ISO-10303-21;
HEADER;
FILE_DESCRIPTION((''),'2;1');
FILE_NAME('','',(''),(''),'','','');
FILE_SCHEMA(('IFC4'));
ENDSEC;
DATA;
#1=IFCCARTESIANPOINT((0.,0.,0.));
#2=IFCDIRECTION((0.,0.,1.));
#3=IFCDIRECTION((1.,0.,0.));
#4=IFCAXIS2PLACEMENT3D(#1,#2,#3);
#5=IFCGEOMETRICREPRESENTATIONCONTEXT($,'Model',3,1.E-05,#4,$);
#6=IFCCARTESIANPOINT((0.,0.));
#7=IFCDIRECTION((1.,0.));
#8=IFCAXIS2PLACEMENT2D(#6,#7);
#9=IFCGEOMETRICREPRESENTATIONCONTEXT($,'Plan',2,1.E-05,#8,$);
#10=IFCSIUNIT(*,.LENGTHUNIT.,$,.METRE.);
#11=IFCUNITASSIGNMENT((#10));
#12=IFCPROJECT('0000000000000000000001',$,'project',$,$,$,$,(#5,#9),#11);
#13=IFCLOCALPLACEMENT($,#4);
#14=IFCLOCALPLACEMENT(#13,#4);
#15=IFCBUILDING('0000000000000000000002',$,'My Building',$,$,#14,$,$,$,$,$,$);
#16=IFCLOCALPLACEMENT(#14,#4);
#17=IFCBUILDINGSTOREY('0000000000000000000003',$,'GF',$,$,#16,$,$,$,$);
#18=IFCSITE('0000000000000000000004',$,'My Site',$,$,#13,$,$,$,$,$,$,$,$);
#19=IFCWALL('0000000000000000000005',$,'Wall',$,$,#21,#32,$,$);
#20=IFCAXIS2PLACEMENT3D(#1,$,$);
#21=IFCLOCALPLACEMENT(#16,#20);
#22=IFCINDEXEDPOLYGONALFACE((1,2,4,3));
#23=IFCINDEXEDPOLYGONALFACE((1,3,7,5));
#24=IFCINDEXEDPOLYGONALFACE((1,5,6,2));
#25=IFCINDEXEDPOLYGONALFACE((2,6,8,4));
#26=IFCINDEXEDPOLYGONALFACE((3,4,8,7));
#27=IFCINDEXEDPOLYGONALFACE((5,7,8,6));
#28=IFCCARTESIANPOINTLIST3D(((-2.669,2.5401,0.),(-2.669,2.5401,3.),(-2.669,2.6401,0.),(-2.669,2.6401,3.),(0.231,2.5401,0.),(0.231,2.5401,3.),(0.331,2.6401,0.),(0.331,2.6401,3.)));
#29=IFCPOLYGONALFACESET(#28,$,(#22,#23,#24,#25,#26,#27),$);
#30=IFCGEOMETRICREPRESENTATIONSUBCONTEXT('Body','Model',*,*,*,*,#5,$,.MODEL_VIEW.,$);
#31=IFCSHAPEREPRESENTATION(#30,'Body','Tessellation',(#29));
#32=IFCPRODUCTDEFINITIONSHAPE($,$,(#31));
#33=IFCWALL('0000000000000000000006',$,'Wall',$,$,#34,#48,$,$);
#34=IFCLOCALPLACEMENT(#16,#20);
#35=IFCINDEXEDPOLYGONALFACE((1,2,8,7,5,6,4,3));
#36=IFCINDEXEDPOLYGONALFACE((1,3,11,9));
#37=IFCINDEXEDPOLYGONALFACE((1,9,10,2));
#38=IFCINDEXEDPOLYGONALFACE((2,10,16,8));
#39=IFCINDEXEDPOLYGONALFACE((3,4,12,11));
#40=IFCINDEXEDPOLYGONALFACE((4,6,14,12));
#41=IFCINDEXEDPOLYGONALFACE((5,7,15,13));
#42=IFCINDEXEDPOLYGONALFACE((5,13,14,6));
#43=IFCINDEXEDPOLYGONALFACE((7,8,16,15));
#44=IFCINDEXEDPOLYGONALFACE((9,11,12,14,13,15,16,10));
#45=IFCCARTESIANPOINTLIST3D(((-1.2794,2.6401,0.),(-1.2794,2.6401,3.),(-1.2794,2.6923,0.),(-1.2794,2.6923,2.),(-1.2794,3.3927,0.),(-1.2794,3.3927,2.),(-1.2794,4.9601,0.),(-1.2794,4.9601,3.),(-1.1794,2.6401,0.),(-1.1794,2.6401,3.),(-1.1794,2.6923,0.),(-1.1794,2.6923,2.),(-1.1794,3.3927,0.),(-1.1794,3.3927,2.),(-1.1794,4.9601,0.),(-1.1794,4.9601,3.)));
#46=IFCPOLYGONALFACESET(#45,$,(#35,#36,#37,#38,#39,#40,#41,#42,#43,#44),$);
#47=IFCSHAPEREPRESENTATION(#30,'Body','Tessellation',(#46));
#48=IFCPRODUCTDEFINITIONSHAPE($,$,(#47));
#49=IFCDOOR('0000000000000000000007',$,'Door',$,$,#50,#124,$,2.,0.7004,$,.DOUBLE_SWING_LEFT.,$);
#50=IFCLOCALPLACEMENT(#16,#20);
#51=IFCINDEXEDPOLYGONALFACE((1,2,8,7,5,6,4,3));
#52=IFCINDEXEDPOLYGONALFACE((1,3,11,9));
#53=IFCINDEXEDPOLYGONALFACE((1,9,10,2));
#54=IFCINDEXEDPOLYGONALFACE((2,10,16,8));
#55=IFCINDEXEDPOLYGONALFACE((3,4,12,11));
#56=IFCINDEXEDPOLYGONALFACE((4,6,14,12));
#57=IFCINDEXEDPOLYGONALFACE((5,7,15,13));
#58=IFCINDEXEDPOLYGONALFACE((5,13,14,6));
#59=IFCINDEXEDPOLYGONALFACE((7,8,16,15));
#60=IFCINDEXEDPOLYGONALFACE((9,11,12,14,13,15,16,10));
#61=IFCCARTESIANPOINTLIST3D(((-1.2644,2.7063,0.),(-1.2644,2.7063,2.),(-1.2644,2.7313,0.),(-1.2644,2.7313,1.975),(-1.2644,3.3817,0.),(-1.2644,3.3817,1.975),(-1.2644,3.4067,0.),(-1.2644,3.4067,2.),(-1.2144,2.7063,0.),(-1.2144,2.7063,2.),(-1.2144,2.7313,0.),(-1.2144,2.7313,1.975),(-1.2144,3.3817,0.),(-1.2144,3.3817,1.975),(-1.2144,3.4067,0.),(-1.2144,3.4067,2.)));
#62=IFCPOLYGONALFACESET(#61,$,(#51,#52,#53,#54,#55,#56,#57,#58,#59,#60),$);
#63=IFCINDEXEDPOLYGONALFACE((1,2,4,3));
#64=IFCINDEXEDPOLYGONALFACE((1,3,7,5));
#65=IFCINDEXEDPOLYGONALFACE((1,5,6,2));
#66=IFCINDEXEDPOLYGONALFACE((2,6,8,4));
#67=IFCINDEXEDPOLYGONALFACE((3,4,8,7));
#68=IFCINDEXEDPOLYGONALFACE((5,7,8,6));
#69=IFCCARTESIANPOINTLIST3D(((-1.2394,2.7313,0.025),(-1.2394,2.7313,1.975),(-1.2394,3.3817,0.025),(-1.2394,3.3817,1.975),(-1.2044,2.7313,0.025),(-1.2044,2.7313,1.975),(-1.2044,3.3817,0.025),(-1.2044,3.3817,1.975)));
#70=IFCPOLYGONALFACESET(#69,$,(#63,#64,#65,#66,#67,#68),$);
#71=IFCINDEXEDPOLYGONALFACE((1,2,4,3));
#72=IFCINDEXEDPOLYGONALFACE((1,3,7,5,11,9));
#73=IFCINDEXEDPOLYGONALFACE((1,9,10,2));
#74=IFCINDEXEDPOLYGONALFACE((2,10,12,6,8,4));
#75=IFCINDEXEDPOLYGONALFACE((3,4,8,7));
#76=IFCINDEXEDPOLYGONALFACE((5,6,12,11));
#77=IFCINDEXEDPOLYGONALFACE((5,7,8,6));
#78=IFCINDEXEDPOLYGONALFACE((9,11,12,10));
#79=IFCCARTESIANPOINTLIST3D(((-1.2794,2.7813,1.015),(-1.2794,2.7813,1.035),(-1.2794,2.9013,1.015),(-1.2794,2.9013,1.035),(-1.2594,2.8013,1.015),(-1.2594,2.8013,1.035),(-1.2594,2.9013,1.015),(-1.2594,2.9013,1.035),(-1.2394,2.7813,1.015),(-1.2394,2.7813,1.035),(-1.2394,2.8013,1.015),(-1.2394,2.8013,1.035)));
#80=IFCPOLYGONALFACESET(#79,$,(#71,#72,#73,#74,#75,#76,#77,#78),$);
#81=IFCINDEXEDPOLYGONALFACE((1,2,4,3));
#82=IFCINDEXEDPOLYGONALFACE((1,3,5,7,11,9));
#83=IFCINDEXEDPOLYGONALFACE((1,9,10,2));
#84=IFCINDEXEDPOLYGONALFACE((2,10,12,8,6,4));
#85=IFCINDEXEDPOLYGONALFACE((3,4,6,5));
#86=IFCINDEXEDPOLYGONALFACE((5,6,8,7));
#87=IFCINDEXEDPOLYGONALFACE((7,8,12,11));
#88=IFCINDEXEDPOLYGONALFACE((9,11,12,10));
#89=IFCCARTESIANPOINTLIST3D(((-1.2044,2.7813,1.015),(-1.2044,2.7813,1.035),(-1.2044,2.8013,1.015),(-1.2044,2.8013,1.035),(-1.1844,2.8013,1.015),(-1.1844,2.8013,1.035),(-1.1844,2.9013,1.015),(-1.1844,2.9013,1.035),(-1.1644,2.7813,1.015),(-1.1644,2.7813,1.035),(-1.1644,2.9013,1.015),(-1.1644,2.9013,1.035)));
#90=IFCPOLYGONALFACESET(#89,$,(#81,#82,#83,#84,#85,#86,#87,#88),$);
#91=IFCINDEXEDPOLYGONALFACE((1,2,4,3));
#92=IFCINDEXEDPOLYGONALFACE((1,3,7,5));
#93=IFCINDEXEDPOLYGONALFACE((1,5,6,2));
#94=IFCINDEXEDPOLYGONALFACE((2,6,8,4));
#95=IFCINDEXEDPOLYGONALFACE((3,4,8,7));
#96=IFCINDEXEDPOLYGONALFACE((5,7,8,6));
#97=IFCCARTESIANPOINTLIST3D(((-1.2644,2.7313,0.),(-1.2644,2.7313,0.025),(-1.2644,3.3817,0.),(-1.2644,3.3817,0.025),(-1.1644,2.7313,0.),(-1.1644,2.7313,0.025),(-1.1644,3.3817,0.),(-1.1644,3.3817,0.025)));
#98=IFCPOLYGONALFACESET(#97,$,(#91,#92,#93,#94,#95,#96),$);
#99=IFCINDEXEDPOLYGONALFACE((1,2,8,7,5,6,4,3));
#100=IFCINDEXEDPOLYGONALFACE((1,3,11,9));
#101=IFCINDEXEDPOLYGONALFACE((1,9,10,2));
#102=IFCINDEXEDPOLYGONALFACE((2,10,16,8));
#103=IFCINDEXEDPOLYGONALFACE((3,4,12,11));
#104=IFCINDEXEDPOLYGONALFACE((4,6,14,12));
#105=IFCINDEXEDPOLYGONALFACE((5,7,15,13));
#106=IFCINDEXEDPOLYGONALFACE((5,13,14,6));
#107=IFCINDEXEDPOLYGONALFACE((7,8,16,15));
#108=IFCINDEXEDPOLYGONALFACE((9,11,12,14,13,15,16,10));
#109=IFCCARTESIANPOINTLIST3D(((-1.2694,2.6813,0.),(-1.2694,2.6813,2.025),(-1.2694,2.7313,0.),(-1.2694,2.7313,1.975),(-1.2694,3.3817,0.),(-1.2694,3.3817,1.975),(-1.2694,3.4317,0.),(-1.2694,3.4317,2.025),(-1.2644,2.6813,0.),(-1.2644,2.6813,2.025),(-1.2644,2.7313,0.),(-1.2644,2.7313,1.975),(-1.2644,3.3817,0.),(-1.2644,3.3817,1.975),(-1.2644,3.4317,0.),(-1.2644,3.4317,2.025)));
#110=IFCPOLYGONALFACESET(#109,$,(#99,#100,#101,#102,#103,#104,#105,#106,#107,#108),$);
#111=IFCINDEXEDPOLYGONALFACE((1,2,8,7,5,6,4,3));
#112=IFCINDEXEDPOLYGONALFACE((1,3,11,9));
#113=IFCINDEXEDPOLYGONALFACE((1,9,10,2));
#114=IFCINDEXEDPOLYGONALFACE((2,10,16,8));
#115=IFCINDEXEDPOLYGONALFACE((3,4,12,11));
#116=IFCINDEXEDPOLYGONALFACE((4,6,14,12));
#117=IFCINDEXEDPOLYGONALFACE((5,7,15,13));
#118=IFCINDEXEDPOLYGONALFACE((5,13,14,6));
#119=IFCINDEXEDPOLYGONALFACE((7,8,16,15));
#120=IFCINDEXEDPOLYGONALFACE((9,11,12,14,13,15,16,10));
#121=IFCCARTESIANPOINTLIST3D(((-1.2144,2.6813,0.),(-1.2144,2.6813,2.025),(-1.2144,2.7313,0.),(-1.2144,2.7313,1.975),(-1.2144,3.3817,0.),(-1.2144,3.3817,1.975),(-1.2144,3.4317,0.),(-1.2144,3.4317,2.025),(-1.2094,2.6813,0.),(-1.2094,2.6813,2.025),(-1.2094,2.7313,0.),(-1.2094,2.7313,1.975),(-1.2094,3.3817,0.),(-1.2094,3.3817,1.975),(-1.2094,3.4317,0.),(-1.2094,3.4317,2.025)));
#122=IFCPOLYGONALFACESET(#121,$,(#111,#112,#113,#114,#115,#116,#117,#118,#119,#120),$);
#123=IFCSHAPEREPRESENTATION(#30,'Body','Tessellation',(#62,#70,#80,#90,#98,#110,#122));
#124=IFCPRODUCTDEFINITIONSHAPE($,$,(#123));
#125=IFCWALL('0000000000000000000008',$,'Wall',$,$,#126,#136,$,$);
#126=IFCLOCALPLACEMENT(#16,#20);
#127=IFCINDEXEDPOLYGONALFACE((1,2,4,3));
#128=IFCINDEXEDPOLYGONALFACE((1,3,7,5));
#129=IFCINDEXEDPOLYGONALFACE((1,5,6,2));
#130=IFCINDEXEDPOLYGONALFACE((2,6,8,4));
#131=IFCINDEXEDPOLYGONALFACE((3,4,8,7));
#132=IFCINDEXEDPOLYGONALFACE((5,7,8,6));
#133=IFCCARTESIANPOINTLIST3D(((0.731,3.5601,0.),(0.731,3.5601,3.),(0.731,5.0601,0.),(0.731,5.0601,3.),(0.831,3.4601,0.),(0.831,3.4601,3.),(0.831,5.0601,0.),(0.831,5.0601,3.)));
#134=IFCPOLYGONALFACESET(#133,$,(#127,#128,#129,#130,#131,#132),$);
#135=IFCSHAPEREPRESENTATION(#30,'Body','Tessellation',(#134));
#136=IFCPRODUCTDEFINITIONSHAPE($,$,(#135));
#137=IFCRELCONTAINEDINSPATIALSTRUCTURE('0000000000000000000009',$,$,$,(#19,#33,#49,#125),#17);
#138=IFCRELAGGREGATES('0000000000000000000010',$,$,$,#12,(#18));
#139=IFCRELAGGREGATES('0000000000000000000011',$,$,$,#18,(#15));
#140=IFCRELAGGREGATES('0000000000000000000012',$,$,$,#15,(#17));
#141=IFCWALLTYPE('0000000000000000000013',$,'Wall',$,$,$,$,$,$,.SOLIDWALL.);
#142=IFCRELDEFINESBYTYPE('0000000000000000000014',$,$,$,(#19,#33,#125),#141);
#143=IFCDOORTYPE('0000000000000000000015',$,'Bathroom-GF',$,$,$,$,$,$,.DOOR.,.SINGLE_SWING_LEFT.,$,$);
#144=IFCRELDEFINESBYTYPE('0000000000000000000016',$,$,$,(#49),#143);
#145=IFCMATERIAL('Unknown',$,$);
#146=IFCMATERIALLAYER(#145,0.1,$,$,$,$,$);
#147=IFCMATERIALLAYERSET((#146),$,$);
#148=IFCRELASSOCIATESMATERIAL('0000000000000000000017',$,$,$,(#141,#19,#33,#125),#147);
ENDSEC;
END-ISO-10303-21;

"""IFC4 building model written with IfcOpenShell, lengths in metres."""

from ifc_helpers import new_model, entity, si_unit, frame, origin_with_axes, origin_2d_with_axis, place, context, subcontext, project, spatial, line, indexed_curve, outline, extrude, shape, source, transform, mapped, material, layer, layer_set, layer_usage, type_object, type_shapes, element, fill, save


model = new_model("IFC4")

# Units and contexts
model_context = context("Model", 3, precision=1e-05, world=origin_with_axes())
plan_context = context("Plan", 2, precision=1e-05, world=origin_2d_with_axis())
body_context_1 = subcontext(model_context, "Body", "Model", "MODEL_VIEW")
body_context_2 = subcontext(plan_context, "Body", "Plan", "PLAN_VIEW")
ifc_project = project(units=[si_unit("LENGTHUNIT", "METRE")], contexts=[model_context, plan_context])

# Site, building, storey
site_placement = place(None, origin_with_axes())
site = spatial("IfcSite", under=ifc_project, at=site_placement, Name="My Site")
building_placement = place(site_placement, origin_with_axes())
building = spatial("IfcBuilding", under=site, at=building_placement, Name="My Building")
storey_placement = place(building_placement, origin_with_axes())
storey = spatial("IfcBuildingStorey", under=building, at=storey_placement, Name="GF")

# Shared definitions
ifc_material_1 = material(Name="Unknown")

# Shared definitions
ifc_layer_1 = layer(ifc_material_1, 0.1)
ifc_layer_set_1 = layer_set([ifc_layer_1])
wall_type = type_object("IfcWallType", Name="Wall", PredefinedType="SOLIDWALL", material=ifc_layer_set_1)

# Wall
ifc_layer_usage_1 = layer_usage(ifc_layer_set_1, "AXIS2", "POSITIVE", 0.0)
wall_1_placement = place(storey_placement, frame((0.331, 2.6401, 0.0), z_axis=(0.0, 0.0, 1.0), x_axis=(-1.0, 0.0, 0.0)))
element("IfcWall", 1, at=wall_1_placement, inside=storey, type_object=wall_type, material=ifc_layer_usage_1, Name="Wall", context=body_context_1, shape_type="SweptSolid", body=[
    extrude(outline(indexed_curve([(0.0, 0.0), (0.1, 0.1), (3.0, 0.1), (3.0, 0.0)], segments=[line(1, 2, 3, 4, 1)])), origin_with_axes(), (0.0, 0.0, 1.0), 3.0),
])

# Wall, opening, door
ifc_layer_usage_2 = layer_usage(ifc_layer_set_1, "AXIS2", "POSITIVE", 0.0)
wall_2_placement = place(storey_placement, frame((-1.1794, 2.6401, 0.0), z_axis=(0.0, 0.0, 1.0), x_axis=(0.0, 1.0, 0.0)))
wall_2 = element("IfcWall", 2, at=wall_2_placement, inside=storey, type_object=wall_type, material=ifc_layer_usage_2, Name="Wall", context=body_context_1, shape_type="SweptSolid", body=[
    extrude(outline(indexed_curve([(0.0, 0.0), (0.0, 0.1), (2.32, 0.1), (2.32, 0.0)], segments=[line(1, 2, 3, 4, 1)])), origin_with_axes(), (0.0, 0.0, 1.0), 3.0),
])
shared_shape_1 = source(origin_with_axes(), body_context_1, "Body", "SweptSolid", [
    extrude(outline(indexed_curve([(0.0, 0.0), (0.7004, 0.0), (0.7004, 2.0), (0.0, 2.0)], segments=[line(1, 2, 3, 4, 1)])), frame((0.0, -0.6, 0.0), z_axis=(0.0, -1.0, 0.0), x_axis=(1.0, 0.0, 0.0)), (0.0, 0.0, -1.0), 1.2),
])
opening_1_placement = place(wall_2_placement, frame((0.0522, 0.0, 0.0), z_axis=(0.0, 0.0, 1.0), x_axis=(1.0, 0.0, 0.0)))
opening_1 = element("IfcOpeningElement", 3, at=opening_1_placement, cuts=wall_2, PredefinedType="OPENING", context=body_context_1, shape_type="MappedRepresentation", body=[
    mapped(shared_shape_1, transform((0.0, 0.0, 0.0), x_axis=(1.0, 0.0, 0.0), y_axis=(0.0, 1.0, 0.0), z_axis=(0.0, 0.0, 1.0), scale=1.0)),
])
door_type_1 = type_object("IfcDoorType", Name="Bathroom-GF", OperationType="SINGLE_SWING_LEFT", PredefinedType="DOOR")
shared_shape_2 = source(origin_with_axes(), body_context_1, "Body", "SweptSolid", [
    extrude(outline(indexed_curve([(0.0, 0.0), (0.0, 2.0), (0.7004, 2.0), (0.7004, 0.0), (0.6754, 0.0), (0.6754, 1.975), (0.025, 1.975), (0.025, 0.0)], segments=[line(1, 2, 3, 4, 5, 6, 7, 8, 1)])), frame((0.0, 0.0, 0.0), z_axis=(0.0, -1.0, 0.0), x_axis=(1.0, 0.0, 0.0)), (0.0, 0.0, -1.0), 0.05),
    extrude(outline(indexed_curve([(0.0, 0.0), (0.6504, 0.0), (0.6504, 0.035), (0.0, 0.035)], segments=[line(1, 2, 3, 4, 1)])), frame((0.025, 0.025, 0.025), z_axis=(0.0, 0.0, 1.0), x_axis=(1.0, 0.0, 0.0)), (0.0, 0.0, 1.0), 1.95),
    extrude(outline(indexed_curve([(0.0, 0.0), (0.0, -0.04), (-0.12, -0.04), (-0.12, -0.02), (-0.02, -0.02), (-0.02, 0.0)], segments=[line(1, 2, 3, 4, 5, 6, 1)])), frame((0.6254, 0.025, 1.015), z_axis=(0.0, 0.0, 1.0), x_axis=(1.0, 0.0, 0.0)), (0.0, 0.0, 1.0), 0.02),
    extrude(outline(indexed_curve([(0.0, 0.0), (0.0, 0.04), (-0.12, 0.04), (-0.12, 0.02), (-0.02, 0.02), (-0.02, 0.0)], segments=[line(1, 2, 3, 4, 5, 6, 1)])), frame((0.6254, 0.06, 1.015), z_axis=(0.0, 0.0, 1.0), x_axis=(1.0, 0.0, 0.0)), (0.0, 0.0, 1.0), 0.02),
    extrude(outline(indexed_curve([(0.0, 0.0), (0.6504, 0.0), (0.6504, 0.1), (0.0, 0.1)], segments=[line(1, 2, 3, 4, 1)])), frame((0.025, 0.0, 0.0), z_axis=(0.0, 0.0, 1.0), x_axis=(1.0, 0.0, 0.0)), (0.0, 0.0, 1.0), 0.025),
    extrude(outline(indexed_curve([(0.0, 0.0), (0.0, 2.025), (0.7504, 2.025), (0.7504, 0.0), (0.7004, 0.0), (0.7004, 1.975), (0.05, 1.975), (0.05, 0.0)], segments=[line(1, 2, 3, 4, 5, 6, 7, 8, 1)])), frame((-0.025, -0.005, 0.0), z_axis=(0.0, -1.0, 0.0), x_axis=(1.0, 0.0, 0.0)), (0.0, 0.0, -1.0), 0.005),
    extrude(outline(indexed_curve([(0.0, 0.0), (0.0, 2.025), (0.7504, 2.025), (0.7504, 0.0), (0.7004, 0.0), (0.7004, 1.975), (0.05, 1.975), (0.05, 0.0)], segments=[line(1, 2, 3, 4, 5, 6, 7, 8, 1)])), frame((-0.025, 0.05, 0.0), z_axis=(0.0, -1.0, 0.0), x_axis=(1.0, 0.0, 0.0)), (0.0, 0.0, -1.0), 0.005),
])
shared_shape_3 = source(origin_with_axes(), body_context_2, "Body", "Curve2D", [
    entity("IfcIndexedPolyCurve", entity("IfcCartesianPointList2D", [[0.0, 0.0], [0.025, 0.0], [0.025, 0.05], [0.0, 0.05]]), [entity("IfcLineIndex", [1, 2, 3, 4, 1])]),
    entity("IfcIndexedPolyCurve", entity("IfcCartesianPointList2D", [[0.7004, 0.0], [0.6754, 0.0], [0.6754, 0.05], [0.7004, 0.05]]), [entity("IfcLineIndex", [1, 2, 3, 4, 1])]),
    entity("IfcIndexedPolyCurve", entity("IfcCartesianPointList2D", [[0.025, 0.05], [0.025, -0.6004], [0.06, -0.6004]])),
    entity("IfcTrimmedCurve", entity("IfcEllipse", entity("IfcAxis2Placement2D", entity("IfcCartesianPoint", [0.06, 0.05]), entity("IfcDirection", [1.0, 0.0])), 0.6154, 0.6504), [entity("IfcCartesianPoint", [0.06, -0.6004])], [entity("IfcCartesianPoint", [0.06, 0.7004])], True, "CARTESIAN"),
    entity("IfcIndexedPolyCurve", entity("IfcCartesianPointList2D", [[0.025, 0.05], [0.06, 0.05], [0.06, 0.7004], [0.025, 0.7004]]), [entity("IfcLineIndex", [1, 2, 3, 4, 1])]),
])
type_shapes(door_type_1, [shared_shape_2, shared_shape_3])
door_1_placement = place(opening_1_placement, frame((0.7144, 0.085, 0.0), z_axis=(0.0, 0.0, 1.0), x_axis=(-1.0, 0.0, 0.0)))
door_1 = element("IfcDoor", 4, at=door_1_placement, inside=storey, type_object=door_type_1, Name="Door", OperationType="DOUBLE_SWING_LEFT", OverallHeight=2.0, OverallWidth=0.7004, shapes=[
    shape(body_context_1, "Body", "MappedRepresentation", [mapped(shared_shape_2, transform((0.0, 0.0, 0.0), x_axis=(1.0, 0.0, 0.0), y_axis=(0.0, 1.0, 0.0), z_axis=(0.0, 0.0, 1.0), scale=1.0))]),
    shape(body_context_2, "Body", "MappedRepresentation", [mapped(shared_shape_3, transform((0.0, 0.0, 0.0), x_axis=(1.0, 0.0, 0.0), y_axis=(0.0, 1.0, 0.0), z_axis=(0.0, 0.0, 1.0), scale=1.0))]),
])
fill(opening_1, door_1)

# Wall
ifc_layer_usage_3 = layer_usage(ifc_layer_set_1, "AXIS2", "POSITIVE", 0.0)
wall_3_placement = place(storey_placement, frame((0.731, 5.0601, 0.0), z_axis=(0.0, 0.0, 1.0), x_axis=(0.0, -1.0, 0.0)))
element("IfcWall", 5, at=wall_3_placement, inside=storey, type_object=wall_type, material=ifc_layer_usage_3, Name="Wall", context=body_context_1, shape_type="SweptSolid", body=[
    extrude(outline(indexed_curve([(0.0, 0.0), (0.0, 0.1), (1.6, 0.1), (1.5, 0.0)], segments=[line(1, 2, 3, 4, 1)])), origin_with_axes(), (0.0, 0.0, 1.0), 3.0),
])

save(model, "model.ifc")
